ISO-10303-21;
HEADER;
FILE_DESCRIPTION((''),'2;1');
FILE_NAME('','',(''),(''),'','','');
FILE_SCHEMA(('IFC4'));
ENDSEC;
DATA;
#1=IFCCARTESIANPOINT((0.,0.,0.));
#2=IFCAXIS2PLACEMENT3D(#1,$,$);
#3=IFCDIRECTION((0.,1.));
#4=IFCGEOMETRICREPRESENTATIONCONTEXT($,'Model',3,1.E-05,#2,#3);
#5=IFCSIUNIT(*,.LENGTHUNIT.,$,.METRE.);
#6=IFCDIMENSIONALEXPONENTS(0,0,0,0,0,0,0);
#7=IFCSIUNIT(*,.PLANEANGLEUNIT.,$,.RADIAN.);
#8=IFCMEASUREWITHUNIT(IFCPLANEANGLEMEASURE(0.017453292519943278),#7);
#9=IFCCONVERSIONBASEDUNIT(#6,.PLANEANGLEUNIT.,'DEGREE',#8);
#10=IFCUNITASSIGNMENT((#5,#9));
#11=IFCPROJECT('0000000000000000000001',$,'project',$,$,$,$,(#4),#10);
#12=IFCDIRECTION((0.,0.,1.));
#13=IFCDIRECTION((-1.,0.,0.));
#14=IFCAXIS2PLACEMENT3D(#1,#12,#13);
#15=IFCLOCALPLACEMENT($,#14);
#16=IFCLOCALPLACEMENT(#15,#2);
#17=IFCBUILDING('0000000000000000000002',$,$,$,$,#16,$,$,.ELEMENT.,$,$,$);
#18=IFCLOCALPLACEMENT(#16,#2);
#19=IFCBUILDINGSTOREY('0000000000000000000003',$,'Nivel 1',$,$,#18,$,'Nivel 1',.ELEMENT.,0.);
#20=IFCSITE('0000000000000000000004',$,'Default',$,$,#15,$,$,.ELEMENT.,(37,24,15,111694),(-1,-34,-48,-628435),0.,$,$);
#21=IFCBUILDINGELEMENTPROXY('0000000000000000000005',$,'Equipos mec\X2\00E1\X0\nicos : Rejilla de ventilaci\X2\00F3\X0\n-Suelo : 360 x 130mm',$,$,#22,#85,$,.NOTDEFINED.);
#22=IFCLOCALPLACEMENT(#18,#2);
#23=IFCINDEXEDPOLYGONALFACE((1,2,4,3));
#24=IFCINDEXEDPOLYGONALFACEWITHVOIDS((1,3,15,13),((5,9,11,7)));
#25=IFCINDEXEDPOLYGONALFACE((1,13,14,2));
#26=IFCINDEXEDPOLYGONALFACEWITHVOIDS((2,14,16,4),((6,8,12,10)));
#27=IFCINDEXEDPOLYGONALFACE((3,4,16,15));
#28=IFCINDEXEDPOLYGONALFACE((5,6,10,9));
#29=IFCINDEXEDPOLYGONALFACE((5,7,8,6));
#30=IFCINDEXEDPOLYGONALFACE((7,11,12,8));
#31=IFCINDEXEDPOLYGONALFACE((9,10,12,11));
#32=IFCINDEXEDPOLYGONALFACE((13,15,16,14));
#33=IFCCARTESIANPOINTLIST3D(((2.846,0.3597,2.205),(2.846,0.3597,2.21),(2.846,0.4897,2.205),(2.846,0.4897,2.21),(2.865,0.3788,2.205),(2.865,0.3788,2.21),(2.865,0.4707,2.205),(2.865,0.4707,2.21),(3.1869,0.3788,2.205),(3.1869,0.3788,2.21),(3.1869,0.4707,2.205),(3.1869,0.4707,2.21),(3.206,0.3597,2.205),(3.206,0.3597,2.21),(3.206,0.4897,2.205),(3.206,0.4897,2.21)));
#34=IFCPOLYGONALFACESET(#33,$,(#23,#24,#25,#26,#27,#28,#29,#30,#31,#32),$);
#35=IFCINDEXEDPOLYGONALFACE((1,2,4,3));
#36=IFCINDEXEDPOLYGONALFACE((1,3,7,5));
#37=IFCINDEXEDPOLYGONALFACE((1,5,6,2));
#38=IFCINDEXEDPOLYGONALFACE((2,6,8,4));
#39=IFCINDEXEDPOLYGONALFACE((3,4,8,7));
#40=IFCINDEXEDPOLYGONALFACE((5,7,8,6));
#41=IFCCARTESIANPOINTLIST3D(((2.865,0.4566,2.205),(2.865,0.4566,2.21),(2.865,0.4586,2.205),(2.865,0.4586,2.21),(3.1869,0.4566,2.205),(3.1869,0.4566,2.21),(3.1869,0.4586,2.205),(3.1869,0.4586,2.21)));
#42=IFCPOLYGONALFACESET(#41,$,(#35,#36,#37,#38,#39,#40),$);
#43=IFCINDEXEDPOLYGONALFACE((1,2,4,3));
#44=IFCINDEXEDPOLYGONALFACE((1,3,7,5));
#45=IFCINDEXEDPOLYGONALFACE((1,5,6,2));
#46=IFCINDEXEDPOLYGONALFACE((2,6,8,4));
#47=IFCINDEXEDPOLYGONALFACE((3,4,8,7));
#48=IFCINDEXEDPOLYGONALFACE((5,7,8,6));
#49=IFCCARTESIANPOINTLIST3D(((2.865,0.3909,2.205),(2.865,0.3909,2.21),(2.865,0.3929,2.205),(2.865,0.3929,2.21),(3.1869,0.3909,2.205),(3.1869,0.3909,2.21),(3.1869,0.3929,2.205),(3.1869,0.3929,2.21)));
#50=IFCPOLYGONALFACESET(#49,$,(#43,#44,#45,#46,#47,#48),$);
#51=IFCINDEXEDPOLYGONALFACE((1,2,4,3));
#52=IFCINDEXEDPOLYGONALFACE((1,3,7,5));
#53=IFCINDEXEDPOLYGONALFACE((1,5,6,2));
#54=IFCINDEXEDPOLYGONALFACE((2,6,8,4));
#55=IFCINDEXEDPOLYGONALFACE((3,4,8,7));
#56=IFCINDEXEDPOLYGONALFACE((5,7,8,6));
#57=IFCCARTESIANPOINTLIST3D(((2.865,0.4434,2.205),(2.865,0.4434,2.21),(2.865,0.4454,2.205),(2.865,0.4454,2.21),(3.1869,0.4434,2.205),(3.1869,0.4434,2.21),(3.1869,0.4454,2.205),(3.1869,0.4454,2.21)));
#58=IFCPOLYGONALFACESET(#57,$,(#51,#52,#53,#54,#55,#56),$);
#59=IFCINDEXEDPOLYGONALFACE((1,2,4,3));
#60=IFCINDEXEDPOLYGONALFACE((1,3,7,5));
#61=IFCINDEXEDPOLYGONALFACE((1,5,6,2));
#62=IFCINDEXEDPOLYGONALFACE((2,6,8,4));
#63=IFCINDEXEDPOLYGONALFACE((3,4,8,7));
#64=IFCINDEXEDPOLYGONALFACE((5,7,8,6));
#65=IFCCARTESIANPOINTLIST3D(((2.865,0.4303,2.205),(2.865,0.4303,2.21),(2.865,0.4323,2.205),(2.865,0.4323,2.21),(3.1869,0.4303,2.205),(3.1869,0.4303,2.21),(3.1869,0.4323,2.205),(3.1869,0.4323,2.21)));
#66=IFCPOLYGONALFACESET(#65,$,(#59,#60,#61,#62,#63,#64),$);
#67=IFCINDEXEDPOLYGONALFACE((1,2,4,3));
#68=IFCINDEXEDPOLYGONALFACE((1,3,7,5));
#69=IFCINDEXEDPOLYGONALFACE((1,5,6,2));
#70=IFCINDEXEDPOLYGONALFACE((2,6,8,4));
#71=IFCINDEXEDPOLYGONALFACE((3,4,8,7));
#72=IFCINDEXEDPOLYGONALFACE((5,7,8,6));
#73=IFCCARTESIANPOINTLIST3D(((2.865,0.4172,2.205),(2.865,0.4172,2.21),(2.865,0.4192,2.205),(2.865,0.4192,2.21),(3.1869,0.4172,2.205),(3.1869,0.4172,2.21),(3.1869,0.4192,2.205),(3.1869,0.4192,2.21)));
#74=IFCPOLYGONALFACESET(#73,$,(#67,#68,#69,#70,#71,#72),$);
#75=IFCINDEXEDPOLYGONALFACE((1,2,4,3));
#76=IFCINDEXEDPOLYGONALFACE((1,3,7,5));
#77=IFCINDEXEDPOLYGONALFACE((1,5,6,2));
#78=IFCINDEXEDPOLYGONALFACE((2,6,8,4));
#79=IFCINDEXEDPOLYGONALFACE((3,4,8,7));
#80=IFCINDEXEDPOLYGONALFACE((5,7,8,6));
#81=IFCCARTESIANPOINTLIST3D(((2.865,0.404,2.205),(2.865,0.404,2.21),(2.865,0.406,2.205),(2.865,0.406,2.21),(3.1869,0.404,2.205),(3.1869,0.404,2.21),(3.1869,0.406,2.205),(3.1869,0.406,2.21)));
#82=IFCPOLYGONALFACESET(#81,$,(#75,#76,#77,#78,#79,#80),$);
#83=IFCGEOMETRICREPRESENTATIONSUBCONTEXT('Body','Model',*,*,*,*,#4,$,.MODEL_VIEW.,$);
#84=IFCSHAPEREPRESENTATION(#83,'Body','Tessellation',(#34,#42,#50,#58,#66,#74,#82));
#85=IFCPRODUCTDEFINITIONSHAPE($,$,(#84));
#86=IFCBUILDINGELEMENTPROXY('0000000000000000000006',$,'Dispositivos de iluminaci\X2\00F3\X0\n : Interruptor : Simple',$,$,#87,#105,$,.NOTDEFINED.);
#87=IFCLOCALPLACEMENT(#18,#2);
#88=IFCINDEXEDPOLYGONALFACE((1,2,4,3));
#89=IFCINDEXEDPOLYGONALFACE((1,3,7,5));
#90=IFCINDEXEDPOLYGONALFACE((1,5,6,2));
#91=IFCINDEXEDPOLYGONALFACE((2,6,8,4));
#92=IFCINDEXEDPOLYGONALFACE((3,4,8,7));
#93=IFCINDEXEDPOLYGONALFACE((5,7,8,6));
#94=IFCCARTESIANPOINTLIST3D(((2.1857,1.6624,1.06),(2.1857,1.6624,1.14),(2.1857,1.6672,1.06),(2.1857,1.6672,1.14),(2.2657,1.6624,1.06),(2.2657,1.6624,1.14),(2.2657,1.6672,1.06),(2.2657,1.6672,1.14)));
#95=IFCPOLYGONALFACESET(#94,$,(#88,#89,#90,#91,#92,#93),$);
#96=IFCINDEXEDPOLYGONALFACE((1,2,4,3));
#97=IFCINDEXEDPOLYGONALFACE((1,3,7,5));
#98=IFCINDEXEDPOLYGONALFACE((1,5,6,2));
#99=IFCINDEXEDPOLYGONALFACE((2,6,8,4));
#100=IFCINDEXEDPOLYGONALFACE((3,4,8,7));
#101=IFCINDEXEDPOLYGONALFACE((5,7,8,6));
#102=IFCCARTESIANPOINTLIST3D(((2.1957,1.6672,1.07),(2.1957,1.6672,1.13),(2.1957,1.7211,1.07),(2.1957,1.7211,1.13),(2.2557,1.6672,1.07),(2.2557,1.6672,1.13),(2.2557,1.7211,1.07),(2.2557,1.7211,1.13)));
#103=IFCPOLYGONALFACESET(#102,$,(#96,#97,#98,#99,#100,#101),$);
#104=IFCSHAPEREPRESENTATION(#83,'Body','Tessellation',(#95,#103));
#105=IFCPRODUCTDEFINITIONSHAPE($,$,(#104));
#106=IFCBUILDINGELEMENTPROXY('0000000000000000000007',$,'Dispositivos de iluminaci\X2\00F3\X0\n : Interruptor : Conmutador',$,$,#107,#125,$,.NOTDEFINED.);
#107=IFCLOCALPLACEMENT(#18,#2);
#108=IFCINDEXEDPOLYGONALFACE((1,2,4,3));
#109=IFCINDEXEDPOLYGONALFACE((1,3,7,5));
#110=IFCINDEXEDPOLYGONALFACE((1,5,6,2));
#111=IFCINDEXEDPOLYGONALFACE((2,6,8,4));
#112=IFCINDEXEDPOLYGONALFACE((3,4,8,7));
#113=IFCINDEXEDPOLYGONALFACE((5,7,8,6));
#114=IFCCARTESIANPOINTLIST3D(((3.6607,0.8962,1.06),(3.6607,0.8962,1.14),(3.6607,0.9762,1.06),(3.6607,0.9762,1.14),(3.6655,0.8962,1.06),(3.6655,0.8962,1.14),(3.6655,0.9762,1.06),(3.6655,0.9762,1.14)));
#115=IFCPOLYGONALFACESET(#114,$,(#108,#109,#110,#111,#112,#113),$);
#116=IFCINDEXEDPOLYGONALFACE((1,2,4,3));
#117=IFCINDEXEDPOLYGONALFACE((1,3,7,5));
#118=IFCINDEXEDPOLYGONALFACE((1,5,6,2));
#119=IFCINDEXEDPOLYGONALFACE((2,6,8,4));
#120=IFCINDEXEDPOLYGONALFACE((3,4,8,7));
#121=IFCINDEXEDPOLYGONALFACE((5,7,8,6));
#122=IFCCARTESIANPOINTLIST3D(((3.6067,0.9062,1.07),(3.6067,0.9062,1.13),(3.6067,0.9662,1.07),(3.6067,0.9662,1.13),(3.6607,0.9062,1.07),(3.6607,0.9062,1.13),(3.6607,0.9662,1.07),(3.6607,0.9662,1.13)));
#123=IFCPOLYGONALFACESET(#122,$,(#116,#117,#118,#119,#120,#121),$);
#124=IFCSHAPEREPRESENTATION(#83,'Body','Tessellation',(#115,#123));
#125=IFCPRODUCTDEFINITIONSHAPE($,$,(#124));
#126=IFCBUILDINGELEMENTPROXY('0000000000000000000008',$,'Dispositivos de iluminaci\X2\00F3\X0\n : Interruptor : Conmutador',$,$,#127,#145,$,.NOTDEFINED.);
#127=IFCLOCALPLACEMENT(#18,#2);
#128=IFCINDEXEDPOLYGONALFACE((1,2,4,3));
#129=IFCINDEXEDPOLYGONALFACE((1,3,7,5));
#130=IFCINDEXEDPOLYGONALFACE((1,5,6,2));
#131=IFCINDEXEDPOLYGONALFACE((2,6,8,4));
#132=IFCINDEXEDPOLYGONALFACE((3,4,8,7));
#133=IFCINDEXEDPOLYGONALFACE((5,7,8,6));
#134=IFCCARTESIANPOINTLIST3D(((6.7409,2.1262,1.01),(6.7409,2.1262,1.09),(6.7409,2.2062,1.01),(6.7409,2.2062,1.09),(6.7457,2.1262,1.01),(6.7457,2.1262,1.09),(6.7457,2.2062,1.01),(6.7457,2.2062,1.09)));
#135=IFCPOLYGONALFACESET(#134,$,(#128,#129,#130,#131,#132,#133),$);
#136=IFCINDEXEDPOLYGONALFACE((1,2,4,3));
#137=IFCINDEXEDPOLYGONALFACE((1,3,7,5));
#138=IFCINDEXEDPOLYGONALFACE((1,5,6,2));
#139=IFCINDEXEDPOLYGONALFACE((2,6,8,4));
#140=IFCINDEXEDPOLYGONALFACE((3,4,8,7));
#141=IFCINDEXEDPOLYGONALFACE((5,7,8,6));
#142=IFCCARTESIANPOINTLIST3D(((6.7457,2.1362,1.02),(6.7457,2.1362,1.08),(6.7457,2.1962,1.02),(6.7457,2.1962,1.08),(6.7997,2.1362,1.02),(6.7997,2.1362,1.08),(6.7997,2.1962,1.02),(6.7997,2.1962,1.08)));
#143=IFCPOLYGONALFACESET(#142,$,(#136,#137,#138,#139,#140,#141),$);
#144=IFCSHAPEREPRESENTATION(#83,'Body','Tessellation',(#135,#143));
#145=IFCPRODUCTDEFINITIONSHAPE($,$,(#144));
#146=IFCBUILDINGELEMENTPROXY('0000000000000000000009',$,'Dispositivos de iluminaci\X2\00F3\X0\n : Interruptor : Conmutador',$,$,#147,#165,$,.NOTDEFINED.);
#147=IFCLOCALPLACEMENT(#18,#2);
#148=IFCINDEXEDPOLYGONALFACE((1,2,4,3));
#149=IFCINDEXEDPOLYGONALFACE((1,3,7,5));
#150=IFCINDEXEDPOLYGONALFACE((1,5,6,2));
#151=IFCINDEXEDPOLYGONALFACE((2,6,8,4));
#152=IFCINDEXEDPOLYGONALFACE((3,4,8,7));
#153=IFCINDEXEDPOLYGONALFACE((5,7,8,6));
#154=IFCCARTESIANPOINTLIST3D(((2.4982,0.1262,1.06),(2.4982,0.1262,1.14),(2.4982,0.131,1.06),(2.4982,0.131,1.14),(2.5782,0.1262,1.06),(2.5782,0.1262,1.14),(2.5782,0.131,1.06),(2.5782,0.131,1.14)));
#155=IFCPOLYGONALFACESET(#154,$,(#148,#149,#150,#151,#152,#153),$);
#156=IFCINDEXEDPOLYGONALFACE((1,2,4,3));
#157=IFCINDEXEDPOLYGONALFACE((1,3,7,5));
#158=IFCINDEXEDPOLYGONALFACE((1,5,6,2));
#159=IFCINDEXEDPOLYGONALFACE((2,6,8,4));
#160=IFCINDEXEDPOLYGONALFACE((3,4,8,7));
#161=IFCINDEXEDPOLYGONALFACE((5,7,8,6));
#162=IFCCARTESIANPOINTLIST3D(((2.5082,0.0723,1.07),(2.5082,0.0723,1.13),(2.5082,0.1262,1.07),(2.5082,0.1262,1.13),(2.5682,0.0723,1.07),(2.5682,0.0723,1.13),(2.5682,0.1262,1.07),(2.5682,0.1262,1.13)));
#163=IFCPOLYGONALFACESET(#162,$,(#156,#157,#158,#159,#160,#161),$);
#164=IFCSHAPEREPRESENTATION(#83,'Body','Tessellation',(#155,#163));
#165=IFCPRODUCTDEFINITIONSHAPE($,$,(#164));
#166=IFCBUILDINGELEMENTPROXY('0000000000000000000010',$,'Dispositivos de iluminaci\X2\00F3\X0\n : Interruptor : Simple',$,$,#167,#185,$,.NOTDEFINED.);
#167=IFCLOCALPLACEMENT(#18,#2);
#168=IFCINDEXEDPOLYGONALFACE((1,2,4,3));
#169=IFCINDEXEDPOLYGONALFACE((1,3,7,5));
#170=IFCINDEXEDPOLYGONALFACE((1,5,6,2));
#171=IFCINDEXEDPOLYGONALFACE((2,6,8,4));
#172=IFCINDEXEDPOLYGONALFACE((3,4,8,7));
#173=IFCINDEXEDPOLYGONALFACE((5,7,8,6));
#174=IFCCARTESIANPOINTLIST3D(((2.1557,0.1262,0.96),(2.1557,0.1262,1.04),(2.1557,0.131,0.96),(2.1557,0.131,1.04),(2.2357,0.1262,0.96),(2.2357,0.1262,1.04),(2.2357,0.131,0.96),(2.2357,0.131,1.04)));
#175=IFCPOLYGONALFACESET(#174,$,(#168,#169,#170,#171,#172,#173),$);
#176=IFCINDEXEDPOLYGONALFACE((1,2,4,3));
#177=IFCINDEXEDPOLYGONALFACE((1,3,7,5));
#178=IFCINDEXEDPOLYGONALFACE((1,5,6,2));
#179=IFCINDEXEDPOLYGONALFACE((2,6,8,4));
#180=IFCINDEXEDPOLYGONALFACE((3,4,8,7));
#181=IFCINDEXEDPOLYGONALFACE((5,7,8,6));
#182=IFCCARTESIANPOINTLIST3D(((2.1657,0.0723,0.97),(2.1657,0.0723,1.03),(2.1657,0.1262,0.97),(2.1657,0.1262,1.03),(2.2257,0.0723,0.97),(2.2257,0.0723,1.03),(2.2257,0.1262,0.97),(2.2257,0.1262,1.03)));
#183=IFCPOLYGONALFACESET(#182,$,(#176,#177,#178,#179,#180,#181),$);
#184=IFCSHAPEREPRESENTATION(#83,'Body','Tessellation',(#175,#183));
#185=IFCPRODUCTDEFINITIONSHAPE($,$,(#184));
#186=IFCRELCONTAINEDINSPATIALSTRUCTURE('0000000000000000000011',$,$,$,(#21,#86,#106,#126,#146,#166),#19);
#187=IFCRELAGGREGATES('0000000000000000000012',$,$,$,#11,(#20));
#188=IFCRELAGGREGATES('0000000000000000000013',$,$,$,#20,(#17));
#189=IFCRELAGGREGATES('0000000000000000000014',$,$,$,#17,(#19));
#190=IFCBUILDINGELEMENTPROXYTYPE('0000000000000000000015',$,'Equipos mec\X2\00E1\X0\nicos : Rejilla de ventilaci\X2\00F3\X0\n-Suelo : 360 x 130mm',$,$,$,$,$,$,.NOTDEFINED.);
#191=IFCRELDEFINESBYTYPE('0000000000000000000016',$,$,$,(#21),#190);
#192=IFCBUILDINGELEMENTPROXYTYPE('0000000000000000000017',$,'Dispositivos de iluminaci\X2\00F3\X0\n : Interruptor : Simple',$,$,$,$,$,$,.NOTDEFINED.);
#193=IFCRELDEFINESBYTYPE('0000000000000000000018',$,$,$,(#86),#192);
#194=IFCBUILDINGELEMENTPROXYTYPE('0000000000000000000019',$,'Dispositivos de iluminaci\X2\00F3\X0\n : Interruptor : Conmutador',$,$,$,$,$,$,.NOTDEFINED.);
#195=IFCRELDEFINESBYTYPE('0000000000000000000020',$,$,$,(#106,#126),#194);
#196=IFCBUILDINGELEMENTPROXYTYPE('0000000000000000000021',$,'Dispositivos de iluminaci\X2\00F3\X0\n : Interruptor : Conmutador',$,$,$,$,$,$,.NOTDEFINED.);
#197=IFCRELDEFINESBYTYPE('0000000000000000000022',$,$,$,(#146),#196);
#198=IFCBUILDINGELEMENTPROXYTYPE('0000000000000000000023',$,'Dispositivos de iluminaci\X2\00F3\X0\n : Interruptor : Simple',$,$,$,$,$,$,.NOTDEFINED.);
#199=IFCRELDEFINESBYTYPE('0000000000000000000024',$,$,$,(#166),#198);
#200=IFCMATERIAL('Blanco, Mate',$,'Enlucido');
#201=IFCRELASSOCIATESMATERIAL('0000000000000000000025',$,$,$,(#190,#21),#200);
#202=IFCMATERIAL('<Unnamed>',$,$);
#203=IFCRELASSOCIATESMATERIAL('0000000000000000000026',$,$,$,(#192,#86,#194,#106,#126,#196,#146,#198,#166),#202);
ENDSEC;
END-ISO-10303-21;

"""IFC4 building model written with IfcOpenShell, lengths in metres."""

from ifc_helpers import new_model, entity, si_unit, converted_unit, direction, frame, origin, place, context, subcontext, project, spatial, indexed_curve, outline, extrude, source, transform, mapped, material, type_object, type_shapes, element, save


model = new_model("IFC4")

# Units and contexts
model_context = context("Model", 3, precision=1e-05, world=origin(), true_north=direction((0.0, 1.0)))
body_context = subcontext(model_context, "Body", "Model", "MODEL_VIEW")
ifc_project = project(units=[si_unit("LENGTHUNIT", "METRE"), converted_unit("PLANEANGLEUNIT", "DEGREE", entity("IfcPlaneAngleMeasure", 0.017453292519943278), si_unit("PLANEANGLEUNIT", "RADIAN"), dimensions=[0, 0, 0, 0, 0, 0, 0])], contexts=[model_context])

# Site, building, storey
site_placement = place(None, frame((0.0, 0.0, 0.0), z_axis=(0.0, 0.0, 1.0), x_axis=(-1.0, 0.0, 0.0)))
site = spatial("IfcSite", under=ifc_project, at=site_placement, Name="Default", CompositionType="ELEMENT", RefLatitude=(37, 24, 15, 111694), RefLongitude=(-1, -34, -48, -628435), RefElevation=0.0)
building_placement = place(site_placement, origin())
building = spatial("IfcBuilding", under=site, at=building_placement, CompositionType="ELEMENT")
storey_placement = place(building_placement, origin())
storey = spatial("IfcBuildingStorey", under=building, at=storey_placement, Name="Nivel 1", LongName="Nivel 1", CompositionType="ELEMENT", Elevation=0.0)

# Shared definitions
ifc_material_1 = material(Name="Blanco, Mate", Category="Enlucido")

# Shared definitions
ifc_material_2 = material(Name="<Unnamed>")

# Building element proxies
building_element_proxy_type_1 = type_object("IfcBuildingElementProxyType", Name="Equipos mecánicos : Rejilla de ventilación-Suelo : 360 x 130mm", PredefinedType="NOTDEFINED", material=ifc_material_1)
shared_shape_1 = source(origin(), body_context, "Body", "SweptSolid", [
    extrude(outline(indexed_curve([(-0.065, -0.18), (0.065, -0.18), (0.065, 0.18), (-0.065, 0.18), (-0.065, -0.18)], self_intersect=False), holes=[indexed_curve([(-0.0459, -0.1609), (-0.0459, 0.1609), (0.046, 0.1609), (0.046, -0.1609), (-0.0459, -0.1609)], self_intersect=False)]), frame((-0.0022, 0.0015, 0.0), z_axis=(0.0, 0.0, 1.0), x_axis=(0.0, 1.0, 0.0)), (0.0, 0.0, 1.0), 0.005),
    extrude(outline(indexed_curve([(-0.001, -0.1609), (0.001, -0.1609), (0.001, 0.1609), (-0.001, 0.1609), (-0.001, -0.1609)], self_intersect=False)), frame((-0.0022, -0.0313, 0.0), z_axis=(0.0, 0.0, 1.0), x_axis=(0.0, 1.0, 0.0)), (0.0, 0.0, 1.0), 0.005),
    extrude(outline(indexed_curve([(-0.001, -0.1609), (0.001, -0.1609), (0.001, 0.1609), (-0.001, 0.1609), (-0.001, -0.1609)], self_intersect=False)), frame((-0.0022, 0.0343, 0.0), z_axis=(0.0, 0.0, 1.0), x_axis=(0.0, 1.0, 0.0)), (0.0, 0.0, 1.0), 0.005),
    extrude(outline(indexed_curve([(-0.001, -0.1609), (0.001, -0.1609), (0.001, 0.1609), (-0.001, 0.1609), (-0.001, -0.1609)], self_intersect=False)), frame((-0.0022, -0.0182, 0.0), z_axis=(0.0, 0.0, 1.0), x_axis=(0.0, 1.0, 0.0)), (0.0, 0.0, 1.0), 0.005),
    extrude(outline(indexed_curve([(-0.001, -0.1609), (0.001, -0.1609), (0.001, 0.1609), (-0.001, 0.1609), (-0.001, -0.1609)], self_intersect=False)), frame((-0.0022, -0.0051, 0.0), z_axis=(0.0, 0.0, 1.0), x_axis=(0.0, 1.0, 0.0)), (0.0, 0.0, 1.0), 0.005),
    extrude(outline(indexed_curve([(-0.001, -0.1609), (0.001, -0.1609), (0.001, 0.1609), (-0.001, 0.1609), (-0.001, -0.1609)], self_intersect=False)), frame((-0.0022, 0.0081, 0.0), z_axis=(0.0, 0.0, 1.0), x_axis=(0.0, 1.0, 0.0)), (0.0, 0.0, 1.0), 0.005),
    extrude(outline(indexed_curve([(-0.001, -0.1609), (0.001, -0.1609), (0.001, 0.1609), (-0.001, 0.1609), (-0.001, -0.1609)], self_intersect=False)), frame((-0.0022, 0.0212, 0.0), z_axis=(0.0, 0.0, 1.0), x_axis=(0.0, 1.0, 0.0)), (0.0, 0.0, 1.0), 0.005),
])
type_shapes(building_element_proxy_type_1, [shared_shape_1])
proxy_1_placement = place(storey_placement, frame((3.0282, 0.4262, 2.21), z_axis=(0.0, 0.0, -1.0), x_axis=(1.0, 0.0, 0.0)))
element("IfcBuildingElementProxy", 1, at=proxy_1_placement, inside=storey, type_object=building_element_proxy_type_1, material=ifc_material_1, Name="Equipos mecánicos : Rejilla de ventilación-Suelo : 360 x 130mm", PredefinedType="NOTDEFINED", context=body_context, shape_type="MappedRepresentation", body=[
    mapped(shared_shape_1, transform((0.0, 0.0, 0.0), scale=1.0)),
])
building_element_proxy_type_2 = type_object("IfcBuildingElementProxyType", Name="Dispositivos de iluminación : Interruptor : Simple", PredefinedType="NOTDEFINED", material=ifc_material_2)
shared_shape_2 = source(origin(), body_context, "Body", "SweptSolid", [
    extrude(outline(indexed_curve([(-0.04, -0.04), (0.04, -0.04), (0.04, 0.04), (-0.04, 0.04), (-0.04, -0.04)], self_intersect=False)), frame((0.0, 0.0, 0.0), z_axis=(0.0, 0.0, 1.0), x_axis=(0.0, -1.0, 0.0)), (0.0, 0.0, 1.0), 0.0048),
    extrude(outline(indexed_curve([(-0.03, -0.03), (0.03, -0.03), (0.03, 0.03), (-0.03, 0.03), (-0.03, -0.03)], self_intersect=False)), frame((0.0, 0.0, -0.054), z_axis=(0.0, 0.0, 1.0), x_axis=(-1.0, 0.0, 0.0)), (0.0, 0.0, 1.0), 0.054),
])
type_shapes(building_element_proxy_type_2, [shared_shape_2])
proxy_2_placement = place(storey_placement, frame((2.2257, 1.6672, 1.1), z_axis=(0.0, -1.0, 0.0), x_axis=(1.0, 0.0, 0.0)))
element("IfcBuildingElementProxy", 2, at=proxy_2_placement, inside=storey, type_object=building_element_proxy_type_2, material=ifc_material_2, Name="Dispositivos de iluminación : Interruptor : Simple", PredefinedType="NOTDEFINED", context=body_context, shape_type="MappedRepresentation", body=[
    mapped(shared_shape_2, transform((0.0, 0.0, 0.0), scale=1.0)),
])
building_element_proxy_type_3 = type_object("IfcBuildingElementProxyType", Name="Dispositivos de iluminación : Interruptor : Conmutador", PredefinedType="NOTDEFINED", material=ifc_material_2)
shared_shape_3 = source(origin(), body_context, "Body", "SweptSolid", [
    extrude(outline(indexed_curve([(-0.04, -0.04), (0.04, -0.04), (0.04, 0.04), (-0.04, 0.04), (-0.04, -0.04)], self_intersect=False)), frame((0.0, 0.0, 0.0), z_axis=(0.0, 0.0, 1.0), x_axis=(0.0, -1.0, 0.0)), (0.0, 0.0, 1.0), 0.0048),
    extrude(outline(indexed_curve([(-0.03, -0.03), (0.03, -0.03), (0.03, 0.03), (-0.03, 0.03), (-0.03, -0.03)], self_intersect=False)), frame((0.0, 0.0, -0.054), z_axis=(0.0, 0.0, 1.0), x_axis=(-1.0, 0.0, 0.0)), (0.0, 0.0, 1.0), 0.054),
])
type_shapes(building_element_proxy_type_3, [shared_shape_3])
for number, where, z_axis, x_axis, name in (
    (3, (3.6607, 0.9362, 1.1), (1.0, 0.0, 0.0), (0.0, 1.0, 0.0), "Dispositivos de iluminación : Interruptor : Conmutador"),
    (4, (6.7457, 2.1662, 1.05), (-1.0, 0.0, 0.0), (0.0, 0.0, -1.0), "Dispositivos de iluminación : Interruptor : Conmutador"),
):
    element("IfcBuildingElementProxy", number, at=place(storey_placement, frame(where, z_axis=z_axis, x_axis=x_axis)), inside=storey, type_object=building_element_proxy_type_3, material=ifc_material_2, Name=name, PredefinedType="NOTDEFINED", context=body_context, shape_type="MappedRepresentation", body=[
        mapped(shared_shape_3, transform((0.0, 0.0, 0.0), scale=1.0)),
    ])
building_element_proxy_type_4 = type_object("IfcBuildingElementProxyType", Name="Dispositivos de iluminación : Interruptor : Conmutador", PredefinedType="NOTDEFINED", material=ifc_material_2)
shared_shape_4 = source(origin(), body_context, "Body", "SweptSolid", [
    extrude(outline(indexed_curve([(-0.04, -0.04), (0.04, -0.04), (0.04, 0.04), (-0.04, 0.04), (-0.04, -0.04)], self_intersect=False)), frame((0.0, 0.0, 0.0), z_axis=(0.0, 0.0, 1.0), x_axis=(0.0, -1.0, 0.0)), (0.0, 0.0, 1.0), 0.0048),
    extrude(outline(indexed_curve([(-0.03, -0.03), (0.03, -0.03), (0.03, 0.03), (-0.03, 0.03), (-0.03, -0.03)], self_intersect=False)), frame((0.0, 0.0, -0.054), z_axis=(0.0, 0.0, 1.0), x_axis=(-1.0, 0.0, 0.0)), (0.0, 0.0, 1.0), 0.054),
])
type_shapes(building_element_proxy_type_4, [shared_shape_4])
proxy_3_placement = place(storey_placement, frame((2.5382, 0.1262, 1.1), z_axis=(0.0, 1.0, 0.0), x_axis=(-1.0, 0.0, 0.0)))
element("IfcBuildingElementProxy", 5, at=proxy_3_placement, inside=storey, type_object=building_element_proxy_type_4, material=ifc_material_2, Name="Dispositivos de iluminación : Interruptor : Conmutador", PredefinedType="NOTDEFINED", context=body_context, shape_type="MappedRepresentation", body=[
    mapped(shared_shape_4, transform((0.0, 0.0, 0.0), scale=1.0)),
])
building_element_proxy_type_5 = type_object("IfcBuildingElementProxyType", Name="Dispositivos de iluminación : Interruptor : Simple", PredefinedType="NOTDEFINED", material=ifc_material_2)
shared_shape_5 = source(origin(), body_context, "Body", "SweptSolid", [
    extrude(outline(indexed_curve([(-0.04, -0.04), (0.04, -0.04), (0.04, 0.04), (-0.04, 0.04), (-0.04, -0.04)], self_intersect=False)), frame((0.0, 0.0, 0.0), z_axis=(0.0, 0.0, 1.0), x_axis=(0.0, -1.0, 0.0)), (0.0, 0.0, 1.0), 0.0048),
    extrude(outline(indexed_curve([(-0.03, -0.03), (0.03, -0.03), (0.03, 0.03), (-0.03, 0.03), (-0.03, -0.03)], self_intersect=False)), frame((0.0, 0.0, -0.054), z_axis=(0.0, 0.0, 1.0), x_axis=(-1.0, 0.0, 0.0)), (0.0, 0.0, 1.0), 0.054),
])
type_shapes(building_element_proxy_type_5, [shared_shape_5])
for number, where, z_axis, x_axis, name in (
    (6, (2.1957, 0.1262, 1.0), (0.0, 1.0, 0.0), (-1.0, 0.0, 0.0), "Dispositivos de iluminación : Interruptor : Simple"),
):
    element("IfcBuildingElementProxy", number, at=place(storey_placement, frame(where, z_axis=z_axis, x_axis=x_axis)), inside=storey, type_object=building_element_proxy_type_5, material=ifc_material_2, Name=name, PredefinedType="NOTDEFINED", context=body_context, shape_type="MappedRepresentation", body=[
        mapped(shared_shape_5, transform((0.0, 0.0, 0.0), scale=1.0)),
    ])

save(model, "model.ifc")
